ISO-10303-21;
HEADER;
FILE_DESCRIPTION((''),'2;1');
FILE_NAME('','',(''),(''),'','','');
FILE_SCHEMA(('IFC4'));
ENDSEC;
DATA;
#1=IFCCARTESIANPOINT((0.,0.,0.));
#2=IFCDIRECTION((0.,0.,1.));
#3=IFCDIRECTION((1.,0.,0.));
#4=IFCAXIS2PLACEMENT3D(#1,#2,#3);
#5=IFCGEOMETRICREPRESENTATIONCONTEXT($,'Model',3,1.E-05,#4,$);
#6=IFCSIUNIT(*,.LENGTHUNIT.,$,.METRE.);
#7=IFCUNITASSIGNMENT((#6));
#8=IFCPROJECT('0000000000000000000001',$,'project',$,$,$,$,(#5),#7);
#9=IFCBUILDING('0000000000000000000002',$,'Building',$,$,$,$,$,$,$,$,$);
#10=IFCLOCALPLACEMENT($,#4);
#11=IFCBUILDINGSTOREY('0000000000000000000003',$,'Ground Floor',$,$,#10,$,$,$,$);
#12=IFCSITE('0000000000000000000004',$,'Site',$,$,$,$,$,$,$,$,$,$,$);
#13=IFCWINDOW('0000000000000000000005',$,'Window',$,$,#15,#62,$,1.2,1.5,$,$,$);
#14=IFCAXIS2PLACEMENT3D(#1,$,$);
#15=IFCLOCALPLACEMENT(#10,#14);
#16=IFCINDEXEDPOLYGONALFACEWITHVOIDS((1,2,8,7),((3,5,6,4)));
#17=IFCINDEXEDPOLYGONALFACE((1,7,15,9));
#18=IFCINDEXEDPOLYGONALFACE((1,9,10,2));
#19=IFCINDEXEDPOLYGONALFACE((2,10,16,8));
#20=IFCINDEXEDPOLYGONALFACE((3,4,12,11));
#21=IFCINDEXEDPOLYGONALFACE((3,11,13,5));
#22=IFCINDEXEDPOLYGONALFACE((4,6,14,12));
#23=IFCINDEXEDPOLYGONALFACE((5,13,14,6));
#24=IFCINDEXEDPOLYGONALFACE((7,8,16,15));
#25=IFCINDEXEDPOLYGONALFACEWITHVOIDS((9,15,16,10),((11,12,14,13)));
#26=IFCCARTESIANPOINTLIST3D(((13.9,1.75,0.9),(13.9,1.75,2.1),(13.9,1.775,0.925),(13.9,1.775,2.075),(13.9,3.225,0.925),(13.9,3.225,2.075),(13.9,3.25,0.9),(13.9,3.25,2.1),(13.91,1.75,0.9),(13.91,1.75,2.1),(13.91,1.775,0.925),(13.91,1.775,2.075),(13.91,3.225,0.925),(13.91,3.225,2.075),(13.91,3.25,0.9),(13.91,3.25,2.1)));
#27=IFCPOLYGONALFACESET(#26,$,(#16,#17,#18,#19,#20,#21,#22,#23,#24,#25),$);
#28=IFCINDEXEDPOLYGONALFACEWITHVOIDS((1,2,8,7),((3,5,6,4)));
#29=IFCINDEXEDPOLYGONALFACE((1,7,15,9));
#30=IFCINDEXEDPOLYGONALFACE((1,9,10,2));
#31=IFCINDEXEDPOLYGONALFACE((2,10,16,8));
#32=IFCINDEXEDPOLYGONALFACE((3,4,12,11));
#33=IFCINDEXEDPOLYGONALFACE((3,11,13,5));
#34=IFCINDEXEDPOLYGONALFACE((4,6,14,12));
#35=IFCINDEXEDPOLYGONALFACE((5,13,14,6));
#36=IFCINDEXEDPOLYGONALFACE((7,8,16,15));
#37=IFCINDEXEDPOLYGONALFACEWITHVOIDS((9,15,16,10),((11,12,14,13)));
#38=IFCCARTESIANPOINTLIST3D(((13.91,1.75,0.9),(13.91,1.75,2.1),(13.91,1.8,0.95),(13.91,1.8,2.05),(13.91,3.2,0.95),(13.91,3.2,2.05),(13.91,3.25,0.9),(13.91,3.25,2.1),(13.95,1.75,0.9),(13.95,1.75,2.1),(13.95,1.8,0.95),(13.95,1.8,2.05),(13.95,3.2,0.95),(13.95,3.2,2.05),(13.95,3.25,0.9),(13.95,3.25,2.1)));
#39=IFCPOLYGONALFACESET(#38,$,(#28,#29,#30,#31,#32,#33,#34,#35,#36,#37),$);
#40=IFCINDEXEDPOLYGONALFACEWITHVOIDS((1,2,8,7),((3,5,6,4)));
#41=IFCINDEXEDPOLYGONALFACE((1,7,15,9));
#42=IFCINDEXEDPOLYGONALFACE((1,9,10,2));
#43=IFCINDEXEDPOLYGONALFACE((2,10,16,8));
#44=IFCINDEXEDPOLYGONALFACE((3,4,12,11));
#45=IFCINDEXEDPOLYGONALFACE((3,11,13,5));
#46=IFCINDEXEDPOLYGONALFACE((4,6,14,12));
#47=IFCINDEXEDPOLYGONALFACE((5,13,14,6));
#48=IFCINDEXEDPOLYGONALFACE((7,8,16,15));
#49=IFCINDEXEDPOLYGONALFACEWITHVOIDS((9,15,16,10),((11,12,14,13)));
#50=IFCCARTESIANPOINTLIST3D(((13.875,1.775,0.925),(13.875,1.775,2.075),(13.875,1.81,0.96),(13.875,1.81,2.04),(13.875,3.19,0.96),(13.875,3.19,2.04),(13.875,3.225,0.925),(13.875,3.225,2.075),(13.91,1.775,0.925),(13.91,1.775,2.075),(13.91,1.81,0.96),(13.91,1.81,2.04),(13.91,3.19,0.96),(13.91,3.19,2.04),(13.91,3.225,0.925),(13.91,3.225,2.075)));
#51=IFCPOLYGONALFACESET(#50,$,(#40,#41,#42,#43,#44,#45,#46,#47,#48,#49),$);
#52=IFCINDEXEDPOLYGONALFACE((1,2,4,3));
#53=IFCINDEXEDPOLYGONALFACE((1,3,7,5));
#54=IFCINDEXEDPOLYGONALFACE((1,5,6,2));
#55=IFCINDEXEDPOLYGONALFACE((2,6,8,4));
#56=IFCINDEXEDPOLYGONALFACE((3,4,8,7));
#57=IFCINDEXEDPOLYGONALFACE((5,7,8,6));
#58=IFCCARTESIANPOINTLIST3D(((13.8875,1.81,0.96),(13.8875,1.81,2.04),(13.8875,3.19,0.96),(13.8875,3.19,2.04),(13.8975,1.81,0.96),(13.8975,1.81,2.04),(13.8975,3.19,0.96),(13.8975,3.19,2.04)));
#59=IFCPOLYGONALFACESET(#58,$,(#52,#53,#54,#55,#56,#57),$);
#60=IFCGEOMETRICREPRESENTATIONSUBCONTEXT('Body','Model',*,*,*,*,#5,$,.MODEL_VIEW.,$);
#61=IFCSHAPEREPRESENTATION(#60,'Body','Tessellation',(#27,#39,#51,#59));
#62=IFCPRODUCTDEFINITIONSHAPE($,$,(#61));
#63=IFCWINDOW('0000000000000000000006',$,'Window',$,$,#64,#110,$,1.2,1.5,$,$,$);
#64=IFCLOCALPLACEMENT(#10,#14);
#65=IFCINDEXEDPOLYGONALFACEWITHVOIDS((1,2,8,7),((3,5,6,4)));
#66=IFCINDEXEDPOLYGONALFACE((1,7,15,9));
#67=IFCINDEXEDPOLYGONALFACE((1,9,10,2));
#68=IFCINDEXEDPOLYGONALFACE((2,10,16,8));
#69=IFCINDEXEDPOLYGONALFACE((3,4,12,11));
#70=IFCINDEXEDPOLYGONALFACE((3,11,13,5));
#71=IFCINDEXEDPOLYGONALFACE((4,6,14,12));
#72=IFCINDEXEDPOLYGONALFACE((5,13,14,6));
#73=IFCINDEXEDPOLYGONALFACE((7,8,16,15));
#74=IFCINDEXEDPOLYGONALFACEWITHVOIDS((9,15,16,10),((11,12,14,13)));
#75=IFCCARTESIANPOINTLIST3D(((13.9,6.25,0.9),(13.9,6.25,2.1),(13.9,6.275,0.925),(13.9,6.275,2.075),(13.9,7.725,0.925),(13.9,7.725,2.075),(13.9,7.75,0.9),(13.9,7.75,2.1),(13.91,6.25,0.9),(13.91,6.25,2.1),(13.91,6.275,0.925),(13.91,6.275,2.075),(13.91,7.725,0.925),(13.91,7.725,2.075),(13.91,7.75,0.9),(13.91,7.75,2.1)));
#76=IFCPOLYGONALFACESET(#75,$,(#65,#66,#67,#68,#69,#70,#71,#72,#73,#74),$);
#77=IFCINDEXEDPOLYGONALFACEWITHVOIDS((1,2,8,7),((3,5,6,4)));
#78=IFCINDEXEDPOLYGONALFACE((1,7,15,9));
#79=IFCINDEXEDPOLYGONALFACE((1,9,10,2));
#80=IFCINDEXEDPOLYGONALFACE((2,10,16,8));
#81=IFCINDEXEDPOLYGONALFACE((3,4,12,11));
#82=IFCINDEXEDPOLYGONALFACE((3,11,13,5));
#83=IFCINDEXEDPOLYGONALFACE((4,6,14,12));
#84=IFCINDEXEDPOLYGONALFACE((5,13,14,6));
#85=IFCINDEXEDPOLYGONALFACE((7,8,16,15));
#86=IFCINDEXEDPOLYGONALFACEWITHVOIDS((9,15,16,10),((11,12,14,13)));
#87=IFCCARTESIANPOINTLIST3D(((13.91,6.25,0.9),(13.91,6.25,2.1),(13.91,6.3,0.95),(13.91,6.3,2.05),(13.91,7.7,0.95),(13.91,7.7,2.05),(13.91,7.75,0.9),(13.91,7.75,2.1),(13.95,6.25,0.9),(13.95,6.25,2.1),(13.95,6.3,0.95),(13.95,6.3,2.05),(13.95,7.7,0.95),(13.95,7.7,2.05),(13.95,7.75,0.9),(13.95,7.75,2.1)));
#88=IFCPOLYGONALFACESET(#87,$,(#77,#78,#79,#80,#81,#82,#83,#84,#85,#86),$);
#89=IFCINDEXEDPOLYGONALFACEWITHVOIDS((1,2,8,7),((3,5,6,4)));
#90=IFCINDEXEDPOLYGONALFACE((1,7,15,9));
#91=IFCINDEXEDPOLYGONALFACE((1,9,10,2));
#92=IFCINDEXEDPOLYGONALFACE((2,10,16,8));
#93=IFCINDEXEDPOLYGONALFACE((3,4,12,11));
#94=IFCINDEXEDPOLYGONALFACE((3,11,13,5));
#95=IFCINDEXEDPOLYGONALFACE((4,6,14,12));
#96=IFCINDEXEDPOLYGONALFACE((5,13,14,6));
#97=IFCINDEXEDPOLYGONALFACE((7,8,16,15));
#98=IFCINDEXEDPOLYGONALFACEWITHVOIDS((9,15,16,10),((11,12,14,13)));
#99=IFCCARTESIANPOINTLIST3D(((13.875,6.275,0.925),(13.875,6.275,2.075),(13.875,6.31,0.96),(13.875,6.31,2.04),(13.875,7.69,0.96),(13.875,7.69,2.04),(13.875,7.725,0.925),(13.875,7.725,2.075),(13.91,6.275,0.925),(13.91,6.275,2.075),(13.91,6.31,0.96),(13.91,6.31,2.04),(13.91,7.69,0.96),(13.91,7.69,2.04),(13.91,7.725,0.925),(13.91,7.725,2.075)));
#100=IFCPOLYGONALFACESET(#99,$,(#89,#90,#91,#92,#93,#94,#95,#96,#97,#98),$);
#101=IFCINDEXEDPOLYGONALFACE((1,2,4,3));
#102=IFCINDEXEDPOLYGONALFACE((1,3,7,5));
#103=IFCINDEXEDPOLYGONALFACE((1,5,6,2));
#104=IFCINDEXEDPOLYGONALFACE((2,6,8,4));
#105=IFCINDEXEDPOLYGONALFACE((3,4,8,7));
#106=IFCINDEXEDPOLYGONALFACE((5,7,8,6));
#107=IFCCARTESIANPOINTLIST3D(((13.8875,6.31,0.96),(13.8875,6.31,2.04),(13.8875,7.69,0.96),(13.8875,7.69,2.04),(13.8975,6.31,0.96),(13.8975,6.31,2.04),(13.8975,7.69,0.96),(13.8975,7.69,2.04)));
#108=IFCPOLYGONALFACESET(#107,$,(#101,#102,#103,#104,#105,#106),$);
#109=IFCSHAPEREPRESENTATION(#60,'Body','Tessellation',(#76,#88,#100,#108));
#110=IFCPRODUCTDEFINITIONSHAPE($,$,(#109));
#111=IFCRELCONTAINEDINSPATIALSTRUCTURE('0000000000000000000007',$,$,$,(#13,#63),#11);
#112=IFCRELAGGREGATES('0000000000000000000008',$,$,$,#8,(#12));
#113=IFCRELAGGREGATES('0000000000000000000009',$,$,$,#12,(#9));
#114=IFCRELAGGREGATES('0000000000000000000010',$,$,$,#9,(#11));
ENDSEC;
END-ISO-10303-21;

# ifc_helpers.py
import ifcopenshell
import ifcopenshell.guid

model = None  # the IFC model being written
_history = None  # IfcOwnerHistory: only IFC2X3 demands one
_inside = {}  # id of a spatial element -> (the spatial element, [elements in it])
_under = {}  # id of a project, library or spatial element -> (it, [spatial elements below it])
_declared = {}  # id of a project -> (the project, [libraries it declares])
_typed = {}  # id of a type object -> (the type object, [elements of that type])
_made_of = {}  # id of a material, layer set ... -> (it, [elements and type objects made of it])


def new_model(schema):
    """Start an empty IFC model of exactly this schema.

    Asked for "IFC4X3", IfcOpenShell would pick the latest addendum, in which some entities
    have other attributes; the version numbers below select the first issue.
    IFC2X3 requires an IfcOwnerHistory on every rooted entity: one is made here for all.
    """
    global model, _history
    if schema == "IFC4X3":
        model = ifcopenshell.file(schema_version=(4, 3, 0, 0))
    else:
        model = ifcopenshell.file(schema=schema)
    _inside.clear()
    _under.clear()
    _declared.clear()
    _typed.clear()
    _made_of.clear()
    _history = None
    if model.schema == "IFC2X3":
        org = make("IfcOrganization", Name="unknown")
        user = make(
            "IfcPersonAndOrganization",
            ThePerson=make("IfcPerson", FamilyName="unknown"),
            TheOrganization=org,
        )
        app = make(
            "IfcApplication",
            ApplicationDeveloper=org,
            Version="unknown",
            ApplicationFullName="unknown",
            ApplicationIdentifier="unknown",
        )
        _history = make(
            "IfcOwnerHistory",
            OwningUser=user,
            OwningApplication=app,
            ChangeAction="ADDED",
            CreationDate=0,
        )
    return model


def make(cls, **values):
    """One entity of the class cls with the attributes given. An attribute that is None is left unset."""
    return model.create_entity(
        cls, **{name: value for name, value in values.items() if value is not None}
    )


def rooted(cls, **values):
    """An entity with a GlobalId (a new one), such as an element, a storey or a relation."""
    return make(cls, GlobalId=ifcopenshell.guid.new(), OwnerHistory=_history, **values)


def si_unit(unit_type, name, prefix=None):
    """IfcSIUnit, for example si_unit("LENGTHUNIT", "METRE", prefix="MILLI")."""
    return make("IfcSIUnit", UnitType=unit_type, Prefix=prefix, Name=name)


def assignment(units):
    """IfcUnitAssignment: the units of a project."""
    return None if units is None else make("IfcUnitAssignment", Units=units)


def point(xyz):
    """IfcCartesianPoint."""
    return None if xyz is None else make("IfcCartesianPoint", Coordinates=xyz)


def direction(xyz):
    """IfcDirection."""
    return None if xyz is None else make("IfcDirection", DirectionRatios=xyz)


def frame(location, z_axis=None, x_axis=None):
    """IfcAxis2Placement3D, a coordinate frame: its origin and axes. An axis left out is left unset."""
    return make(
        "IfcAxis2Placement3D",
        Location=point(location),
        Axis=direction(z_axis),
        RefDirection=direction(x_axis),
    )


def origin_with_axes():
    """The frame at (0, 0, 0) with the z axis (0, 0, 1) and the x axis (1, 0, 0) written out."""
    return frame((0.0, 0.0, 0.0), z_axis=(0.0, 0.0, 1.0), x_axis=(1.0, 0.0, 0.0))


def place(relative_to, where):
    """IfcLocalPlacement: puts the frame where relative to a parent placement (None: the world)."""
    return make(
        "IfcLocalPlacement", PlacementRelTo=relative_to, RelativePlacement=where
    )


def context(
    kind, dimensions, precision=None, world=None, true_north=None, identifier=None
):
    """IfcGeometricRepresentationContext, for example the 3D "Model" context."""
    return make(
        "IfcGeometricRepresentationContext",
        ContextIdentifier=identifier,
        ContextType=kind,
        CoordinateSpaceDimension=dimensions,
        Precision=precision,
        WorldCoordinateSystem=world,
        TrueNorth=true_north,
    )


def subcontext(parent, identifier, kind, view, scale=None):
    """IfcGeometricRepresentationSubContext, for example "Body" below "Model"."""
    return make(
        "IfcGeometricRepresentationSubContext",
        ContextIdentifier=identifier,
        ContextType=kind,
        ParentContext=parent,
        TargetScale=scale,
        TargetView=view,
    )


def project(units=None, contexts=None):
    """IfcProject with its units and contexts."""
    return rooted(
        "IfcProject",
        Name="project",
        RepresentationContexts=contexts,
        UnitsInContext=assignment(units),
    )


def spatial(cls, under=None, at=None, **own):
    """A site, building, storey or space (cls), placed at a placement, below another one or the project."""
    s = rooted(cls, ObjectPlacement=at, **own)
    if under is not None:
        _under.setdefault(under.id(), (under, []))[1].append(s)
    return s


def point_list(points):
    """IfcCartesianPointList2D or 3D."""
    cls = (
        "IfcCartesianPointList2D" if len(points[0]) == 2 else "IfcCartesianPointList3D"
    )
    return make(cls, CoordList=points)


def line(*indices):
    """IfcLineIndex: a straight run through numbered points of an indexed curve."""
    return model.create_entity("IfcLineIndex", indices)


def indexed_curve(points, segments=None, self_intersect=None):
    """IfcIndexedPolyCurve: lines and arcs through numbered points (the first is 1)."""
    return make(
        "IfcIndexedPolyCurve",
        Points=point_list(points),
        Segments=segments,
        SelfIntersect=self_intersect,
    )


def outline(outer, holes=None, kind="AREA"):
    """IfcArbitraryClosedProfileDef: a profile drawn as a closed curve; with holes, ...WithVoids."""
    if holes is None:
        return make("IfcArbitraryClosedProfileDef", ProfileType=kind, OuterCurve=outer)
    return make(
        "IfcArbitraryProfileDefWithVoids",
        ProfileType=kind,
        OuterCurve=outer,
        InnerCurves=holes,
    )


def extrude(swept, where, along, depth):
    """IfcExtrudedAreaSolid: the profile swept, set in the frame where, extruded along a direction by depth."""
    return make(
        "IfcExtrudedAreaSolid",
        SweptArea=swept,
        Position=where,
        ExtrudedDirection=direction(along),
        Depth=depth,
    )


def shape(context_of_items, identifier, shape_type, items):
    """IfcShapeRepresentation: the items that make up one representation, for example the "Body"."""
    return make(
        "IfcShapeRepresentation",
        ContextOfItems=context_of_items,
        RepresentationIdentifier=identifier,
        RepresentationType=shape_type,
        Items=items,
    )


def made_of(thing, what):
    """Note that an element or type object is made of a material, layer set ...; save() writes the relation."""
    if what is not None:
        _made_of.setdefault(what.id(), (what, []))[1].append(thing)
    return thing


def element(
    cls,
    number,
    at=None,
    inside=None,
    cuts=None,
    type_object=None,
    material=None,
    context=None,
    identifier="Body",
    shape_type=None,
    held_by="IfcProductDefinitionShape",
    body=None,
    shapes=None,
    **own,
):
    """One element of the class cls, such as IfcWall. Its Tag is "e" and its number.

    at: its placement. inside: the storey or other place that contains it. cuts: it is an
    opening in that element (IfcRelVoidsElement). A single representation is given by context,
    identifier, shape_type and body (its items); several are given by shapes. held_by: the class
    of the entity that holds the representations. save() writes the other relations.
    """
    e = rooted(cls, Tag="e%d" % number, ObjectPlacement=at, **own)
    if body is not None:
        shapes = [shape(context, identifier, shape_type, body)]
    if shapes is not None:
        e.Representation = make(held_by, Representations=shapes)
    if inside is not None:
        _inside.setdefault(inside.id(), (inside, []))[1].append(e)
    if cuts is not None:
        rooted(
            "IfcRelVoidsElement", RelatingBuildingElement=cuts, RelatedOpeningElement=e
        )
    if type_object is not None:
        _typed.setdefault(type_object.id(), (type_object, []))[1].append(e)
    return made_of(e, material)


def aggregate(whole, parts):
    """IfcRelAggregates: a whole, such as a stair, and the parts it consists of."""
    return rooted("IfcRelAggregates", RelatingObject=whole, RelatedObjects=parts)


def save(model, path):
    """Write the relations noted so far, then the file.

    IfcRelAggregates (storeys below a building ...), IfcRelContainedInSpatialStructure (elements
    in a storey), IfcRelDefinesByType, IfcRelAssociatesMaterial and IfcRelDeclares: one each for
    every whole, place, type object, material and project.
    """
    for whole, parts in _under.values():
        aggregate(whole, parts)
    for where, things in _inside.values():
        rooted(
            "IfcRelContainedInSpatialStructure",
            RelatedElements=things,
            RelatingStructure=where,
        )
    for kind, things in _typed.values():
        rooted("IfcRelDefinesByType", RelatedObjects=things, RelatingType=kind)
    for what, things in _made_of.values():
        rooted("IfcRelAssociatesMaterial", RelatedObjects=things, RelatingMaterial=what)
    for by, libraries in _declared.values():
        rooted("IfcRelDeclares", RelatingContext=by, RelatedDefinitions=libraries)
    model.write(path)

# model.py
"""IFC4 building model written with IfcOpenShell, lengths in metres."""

from ifc_helpers import new_model, si_unit, frame, origin_with_axes, place, context, subcontext, project, spatial, line, indexed_curve, outline, extrude, element, save


model = new_model("IFC4")

# Units and contexts
model_context = context("Model", 3, precision=1e-05, world=origin_with_axes())
body_context = subcontext(model_context, "Body", "Model", "MODEL_VIEW")
ifc_project = project(units=[si_unit("LENGTHUNIT", "METRE")], contexts=[model_context])

# Site, building, storey
site = spatial("IfcSite", under=ifc_project, Name="Site")
building = spatial("IfcBuilding", under=site, Name="Building")
storey_placement = place(None, origin_with_axes())
storey = spatial("IfcBuildingStorey", under=building, at=storey_placement, Name="Ground Floor")

# Windows
for number, where, z_axis, x_axis, name in (
    (1, (14.0, 1.75, 0.9), (0.0, 0.0, 1.0), (0.0, 1.0, 0.0), "Window"),
    (2, (14.0, 6.25, 0.9), (0.0, 0.0, 1.0), (0.0, 1.0, 0.0), "Window"),
):
    element("IfcWindow", number, at=place(storey_placement, frame(where, z_axis=z_axis, x_axis=x_axis)), inside=storey, Name=name, OverallHeight=1.2, OverallWidth=1.5, context=body_context, shape_type="SweptSolid", body=[
        extrude(outline(indexed_curve([(0.0, 0.0), (1.5, 0.0), (1.5, 1.2), (0.0, 1.2)], segments=[line(1, 2, 3, 4, 1)]), holes=[indexed_curve([(0.025, 0.025), (1.475, 0.025), (1.475, 1.175), (0.025, 1.175)], segments=[line(1, 2, 3, 4, 1)])]), frame((0.0, 0.09, 0.0), z_axis=(0.0, -1.0, 0.0), x_axis=(1.0, 0.0, 0.0)), (0.0, 0.0, -1.0), 0.01),
        extrude(outline(indexed_curve([(0.0, 0.0), (1.5, 0.0), (1.5, 1.2), (0.0, 1.2)], segments=[line(1, 2, 3, 4, 1)]), holes=[indexed_curve([(0.05, 0.05), (1.45, 0.05), (1.45, 1.15), (0.05, 1.15)], segments=[line(1, 2, 3, 4, 1)])]), frame((0.0, 0.05, 0.0), z_axis=(0.0, -1.0, 0.0), x_axis=(1.0, 0.0, 0.0)), (0.0, 0.0, -1.0), 0.04),
        extrude(outline(indexed_curve([(0.0, 0.0), (1.45, 0.0), (1.45, 1.15), (0.0, 1.15)], segments=[line(1, 2, 3, 4, 1)]), holes=[indexed_curve([(0.035, 0.035), (1.415, 0.035), (1.415, 1.115), (0.035, 1.115)], segments=[line(1, 2, 3, 4, 1)])]), frame((0.025, 0.09, 0.025), z_axis=(0.0, -1.0, 0.0), x_axis=(1.0, 0.0, 0.0)), (0.0, 0.0, -1.0), 0.035),
        extrude(outline(indexed_curve([(0.035, 0.035), (1.415, 0.035), (1.415, 1.115), (0.035, 1.115)], segments=[line(1, 2, 3, 4, 1)])), frame((0.025, 0.1025, 0.025), z_axis=(0.0, -1.0, 0.0), x_axis=(1.0, 0.0, 0.0)), (0.0, 0.0, -1.0), 0.01),
    ])

save(model, "model.ifc")
